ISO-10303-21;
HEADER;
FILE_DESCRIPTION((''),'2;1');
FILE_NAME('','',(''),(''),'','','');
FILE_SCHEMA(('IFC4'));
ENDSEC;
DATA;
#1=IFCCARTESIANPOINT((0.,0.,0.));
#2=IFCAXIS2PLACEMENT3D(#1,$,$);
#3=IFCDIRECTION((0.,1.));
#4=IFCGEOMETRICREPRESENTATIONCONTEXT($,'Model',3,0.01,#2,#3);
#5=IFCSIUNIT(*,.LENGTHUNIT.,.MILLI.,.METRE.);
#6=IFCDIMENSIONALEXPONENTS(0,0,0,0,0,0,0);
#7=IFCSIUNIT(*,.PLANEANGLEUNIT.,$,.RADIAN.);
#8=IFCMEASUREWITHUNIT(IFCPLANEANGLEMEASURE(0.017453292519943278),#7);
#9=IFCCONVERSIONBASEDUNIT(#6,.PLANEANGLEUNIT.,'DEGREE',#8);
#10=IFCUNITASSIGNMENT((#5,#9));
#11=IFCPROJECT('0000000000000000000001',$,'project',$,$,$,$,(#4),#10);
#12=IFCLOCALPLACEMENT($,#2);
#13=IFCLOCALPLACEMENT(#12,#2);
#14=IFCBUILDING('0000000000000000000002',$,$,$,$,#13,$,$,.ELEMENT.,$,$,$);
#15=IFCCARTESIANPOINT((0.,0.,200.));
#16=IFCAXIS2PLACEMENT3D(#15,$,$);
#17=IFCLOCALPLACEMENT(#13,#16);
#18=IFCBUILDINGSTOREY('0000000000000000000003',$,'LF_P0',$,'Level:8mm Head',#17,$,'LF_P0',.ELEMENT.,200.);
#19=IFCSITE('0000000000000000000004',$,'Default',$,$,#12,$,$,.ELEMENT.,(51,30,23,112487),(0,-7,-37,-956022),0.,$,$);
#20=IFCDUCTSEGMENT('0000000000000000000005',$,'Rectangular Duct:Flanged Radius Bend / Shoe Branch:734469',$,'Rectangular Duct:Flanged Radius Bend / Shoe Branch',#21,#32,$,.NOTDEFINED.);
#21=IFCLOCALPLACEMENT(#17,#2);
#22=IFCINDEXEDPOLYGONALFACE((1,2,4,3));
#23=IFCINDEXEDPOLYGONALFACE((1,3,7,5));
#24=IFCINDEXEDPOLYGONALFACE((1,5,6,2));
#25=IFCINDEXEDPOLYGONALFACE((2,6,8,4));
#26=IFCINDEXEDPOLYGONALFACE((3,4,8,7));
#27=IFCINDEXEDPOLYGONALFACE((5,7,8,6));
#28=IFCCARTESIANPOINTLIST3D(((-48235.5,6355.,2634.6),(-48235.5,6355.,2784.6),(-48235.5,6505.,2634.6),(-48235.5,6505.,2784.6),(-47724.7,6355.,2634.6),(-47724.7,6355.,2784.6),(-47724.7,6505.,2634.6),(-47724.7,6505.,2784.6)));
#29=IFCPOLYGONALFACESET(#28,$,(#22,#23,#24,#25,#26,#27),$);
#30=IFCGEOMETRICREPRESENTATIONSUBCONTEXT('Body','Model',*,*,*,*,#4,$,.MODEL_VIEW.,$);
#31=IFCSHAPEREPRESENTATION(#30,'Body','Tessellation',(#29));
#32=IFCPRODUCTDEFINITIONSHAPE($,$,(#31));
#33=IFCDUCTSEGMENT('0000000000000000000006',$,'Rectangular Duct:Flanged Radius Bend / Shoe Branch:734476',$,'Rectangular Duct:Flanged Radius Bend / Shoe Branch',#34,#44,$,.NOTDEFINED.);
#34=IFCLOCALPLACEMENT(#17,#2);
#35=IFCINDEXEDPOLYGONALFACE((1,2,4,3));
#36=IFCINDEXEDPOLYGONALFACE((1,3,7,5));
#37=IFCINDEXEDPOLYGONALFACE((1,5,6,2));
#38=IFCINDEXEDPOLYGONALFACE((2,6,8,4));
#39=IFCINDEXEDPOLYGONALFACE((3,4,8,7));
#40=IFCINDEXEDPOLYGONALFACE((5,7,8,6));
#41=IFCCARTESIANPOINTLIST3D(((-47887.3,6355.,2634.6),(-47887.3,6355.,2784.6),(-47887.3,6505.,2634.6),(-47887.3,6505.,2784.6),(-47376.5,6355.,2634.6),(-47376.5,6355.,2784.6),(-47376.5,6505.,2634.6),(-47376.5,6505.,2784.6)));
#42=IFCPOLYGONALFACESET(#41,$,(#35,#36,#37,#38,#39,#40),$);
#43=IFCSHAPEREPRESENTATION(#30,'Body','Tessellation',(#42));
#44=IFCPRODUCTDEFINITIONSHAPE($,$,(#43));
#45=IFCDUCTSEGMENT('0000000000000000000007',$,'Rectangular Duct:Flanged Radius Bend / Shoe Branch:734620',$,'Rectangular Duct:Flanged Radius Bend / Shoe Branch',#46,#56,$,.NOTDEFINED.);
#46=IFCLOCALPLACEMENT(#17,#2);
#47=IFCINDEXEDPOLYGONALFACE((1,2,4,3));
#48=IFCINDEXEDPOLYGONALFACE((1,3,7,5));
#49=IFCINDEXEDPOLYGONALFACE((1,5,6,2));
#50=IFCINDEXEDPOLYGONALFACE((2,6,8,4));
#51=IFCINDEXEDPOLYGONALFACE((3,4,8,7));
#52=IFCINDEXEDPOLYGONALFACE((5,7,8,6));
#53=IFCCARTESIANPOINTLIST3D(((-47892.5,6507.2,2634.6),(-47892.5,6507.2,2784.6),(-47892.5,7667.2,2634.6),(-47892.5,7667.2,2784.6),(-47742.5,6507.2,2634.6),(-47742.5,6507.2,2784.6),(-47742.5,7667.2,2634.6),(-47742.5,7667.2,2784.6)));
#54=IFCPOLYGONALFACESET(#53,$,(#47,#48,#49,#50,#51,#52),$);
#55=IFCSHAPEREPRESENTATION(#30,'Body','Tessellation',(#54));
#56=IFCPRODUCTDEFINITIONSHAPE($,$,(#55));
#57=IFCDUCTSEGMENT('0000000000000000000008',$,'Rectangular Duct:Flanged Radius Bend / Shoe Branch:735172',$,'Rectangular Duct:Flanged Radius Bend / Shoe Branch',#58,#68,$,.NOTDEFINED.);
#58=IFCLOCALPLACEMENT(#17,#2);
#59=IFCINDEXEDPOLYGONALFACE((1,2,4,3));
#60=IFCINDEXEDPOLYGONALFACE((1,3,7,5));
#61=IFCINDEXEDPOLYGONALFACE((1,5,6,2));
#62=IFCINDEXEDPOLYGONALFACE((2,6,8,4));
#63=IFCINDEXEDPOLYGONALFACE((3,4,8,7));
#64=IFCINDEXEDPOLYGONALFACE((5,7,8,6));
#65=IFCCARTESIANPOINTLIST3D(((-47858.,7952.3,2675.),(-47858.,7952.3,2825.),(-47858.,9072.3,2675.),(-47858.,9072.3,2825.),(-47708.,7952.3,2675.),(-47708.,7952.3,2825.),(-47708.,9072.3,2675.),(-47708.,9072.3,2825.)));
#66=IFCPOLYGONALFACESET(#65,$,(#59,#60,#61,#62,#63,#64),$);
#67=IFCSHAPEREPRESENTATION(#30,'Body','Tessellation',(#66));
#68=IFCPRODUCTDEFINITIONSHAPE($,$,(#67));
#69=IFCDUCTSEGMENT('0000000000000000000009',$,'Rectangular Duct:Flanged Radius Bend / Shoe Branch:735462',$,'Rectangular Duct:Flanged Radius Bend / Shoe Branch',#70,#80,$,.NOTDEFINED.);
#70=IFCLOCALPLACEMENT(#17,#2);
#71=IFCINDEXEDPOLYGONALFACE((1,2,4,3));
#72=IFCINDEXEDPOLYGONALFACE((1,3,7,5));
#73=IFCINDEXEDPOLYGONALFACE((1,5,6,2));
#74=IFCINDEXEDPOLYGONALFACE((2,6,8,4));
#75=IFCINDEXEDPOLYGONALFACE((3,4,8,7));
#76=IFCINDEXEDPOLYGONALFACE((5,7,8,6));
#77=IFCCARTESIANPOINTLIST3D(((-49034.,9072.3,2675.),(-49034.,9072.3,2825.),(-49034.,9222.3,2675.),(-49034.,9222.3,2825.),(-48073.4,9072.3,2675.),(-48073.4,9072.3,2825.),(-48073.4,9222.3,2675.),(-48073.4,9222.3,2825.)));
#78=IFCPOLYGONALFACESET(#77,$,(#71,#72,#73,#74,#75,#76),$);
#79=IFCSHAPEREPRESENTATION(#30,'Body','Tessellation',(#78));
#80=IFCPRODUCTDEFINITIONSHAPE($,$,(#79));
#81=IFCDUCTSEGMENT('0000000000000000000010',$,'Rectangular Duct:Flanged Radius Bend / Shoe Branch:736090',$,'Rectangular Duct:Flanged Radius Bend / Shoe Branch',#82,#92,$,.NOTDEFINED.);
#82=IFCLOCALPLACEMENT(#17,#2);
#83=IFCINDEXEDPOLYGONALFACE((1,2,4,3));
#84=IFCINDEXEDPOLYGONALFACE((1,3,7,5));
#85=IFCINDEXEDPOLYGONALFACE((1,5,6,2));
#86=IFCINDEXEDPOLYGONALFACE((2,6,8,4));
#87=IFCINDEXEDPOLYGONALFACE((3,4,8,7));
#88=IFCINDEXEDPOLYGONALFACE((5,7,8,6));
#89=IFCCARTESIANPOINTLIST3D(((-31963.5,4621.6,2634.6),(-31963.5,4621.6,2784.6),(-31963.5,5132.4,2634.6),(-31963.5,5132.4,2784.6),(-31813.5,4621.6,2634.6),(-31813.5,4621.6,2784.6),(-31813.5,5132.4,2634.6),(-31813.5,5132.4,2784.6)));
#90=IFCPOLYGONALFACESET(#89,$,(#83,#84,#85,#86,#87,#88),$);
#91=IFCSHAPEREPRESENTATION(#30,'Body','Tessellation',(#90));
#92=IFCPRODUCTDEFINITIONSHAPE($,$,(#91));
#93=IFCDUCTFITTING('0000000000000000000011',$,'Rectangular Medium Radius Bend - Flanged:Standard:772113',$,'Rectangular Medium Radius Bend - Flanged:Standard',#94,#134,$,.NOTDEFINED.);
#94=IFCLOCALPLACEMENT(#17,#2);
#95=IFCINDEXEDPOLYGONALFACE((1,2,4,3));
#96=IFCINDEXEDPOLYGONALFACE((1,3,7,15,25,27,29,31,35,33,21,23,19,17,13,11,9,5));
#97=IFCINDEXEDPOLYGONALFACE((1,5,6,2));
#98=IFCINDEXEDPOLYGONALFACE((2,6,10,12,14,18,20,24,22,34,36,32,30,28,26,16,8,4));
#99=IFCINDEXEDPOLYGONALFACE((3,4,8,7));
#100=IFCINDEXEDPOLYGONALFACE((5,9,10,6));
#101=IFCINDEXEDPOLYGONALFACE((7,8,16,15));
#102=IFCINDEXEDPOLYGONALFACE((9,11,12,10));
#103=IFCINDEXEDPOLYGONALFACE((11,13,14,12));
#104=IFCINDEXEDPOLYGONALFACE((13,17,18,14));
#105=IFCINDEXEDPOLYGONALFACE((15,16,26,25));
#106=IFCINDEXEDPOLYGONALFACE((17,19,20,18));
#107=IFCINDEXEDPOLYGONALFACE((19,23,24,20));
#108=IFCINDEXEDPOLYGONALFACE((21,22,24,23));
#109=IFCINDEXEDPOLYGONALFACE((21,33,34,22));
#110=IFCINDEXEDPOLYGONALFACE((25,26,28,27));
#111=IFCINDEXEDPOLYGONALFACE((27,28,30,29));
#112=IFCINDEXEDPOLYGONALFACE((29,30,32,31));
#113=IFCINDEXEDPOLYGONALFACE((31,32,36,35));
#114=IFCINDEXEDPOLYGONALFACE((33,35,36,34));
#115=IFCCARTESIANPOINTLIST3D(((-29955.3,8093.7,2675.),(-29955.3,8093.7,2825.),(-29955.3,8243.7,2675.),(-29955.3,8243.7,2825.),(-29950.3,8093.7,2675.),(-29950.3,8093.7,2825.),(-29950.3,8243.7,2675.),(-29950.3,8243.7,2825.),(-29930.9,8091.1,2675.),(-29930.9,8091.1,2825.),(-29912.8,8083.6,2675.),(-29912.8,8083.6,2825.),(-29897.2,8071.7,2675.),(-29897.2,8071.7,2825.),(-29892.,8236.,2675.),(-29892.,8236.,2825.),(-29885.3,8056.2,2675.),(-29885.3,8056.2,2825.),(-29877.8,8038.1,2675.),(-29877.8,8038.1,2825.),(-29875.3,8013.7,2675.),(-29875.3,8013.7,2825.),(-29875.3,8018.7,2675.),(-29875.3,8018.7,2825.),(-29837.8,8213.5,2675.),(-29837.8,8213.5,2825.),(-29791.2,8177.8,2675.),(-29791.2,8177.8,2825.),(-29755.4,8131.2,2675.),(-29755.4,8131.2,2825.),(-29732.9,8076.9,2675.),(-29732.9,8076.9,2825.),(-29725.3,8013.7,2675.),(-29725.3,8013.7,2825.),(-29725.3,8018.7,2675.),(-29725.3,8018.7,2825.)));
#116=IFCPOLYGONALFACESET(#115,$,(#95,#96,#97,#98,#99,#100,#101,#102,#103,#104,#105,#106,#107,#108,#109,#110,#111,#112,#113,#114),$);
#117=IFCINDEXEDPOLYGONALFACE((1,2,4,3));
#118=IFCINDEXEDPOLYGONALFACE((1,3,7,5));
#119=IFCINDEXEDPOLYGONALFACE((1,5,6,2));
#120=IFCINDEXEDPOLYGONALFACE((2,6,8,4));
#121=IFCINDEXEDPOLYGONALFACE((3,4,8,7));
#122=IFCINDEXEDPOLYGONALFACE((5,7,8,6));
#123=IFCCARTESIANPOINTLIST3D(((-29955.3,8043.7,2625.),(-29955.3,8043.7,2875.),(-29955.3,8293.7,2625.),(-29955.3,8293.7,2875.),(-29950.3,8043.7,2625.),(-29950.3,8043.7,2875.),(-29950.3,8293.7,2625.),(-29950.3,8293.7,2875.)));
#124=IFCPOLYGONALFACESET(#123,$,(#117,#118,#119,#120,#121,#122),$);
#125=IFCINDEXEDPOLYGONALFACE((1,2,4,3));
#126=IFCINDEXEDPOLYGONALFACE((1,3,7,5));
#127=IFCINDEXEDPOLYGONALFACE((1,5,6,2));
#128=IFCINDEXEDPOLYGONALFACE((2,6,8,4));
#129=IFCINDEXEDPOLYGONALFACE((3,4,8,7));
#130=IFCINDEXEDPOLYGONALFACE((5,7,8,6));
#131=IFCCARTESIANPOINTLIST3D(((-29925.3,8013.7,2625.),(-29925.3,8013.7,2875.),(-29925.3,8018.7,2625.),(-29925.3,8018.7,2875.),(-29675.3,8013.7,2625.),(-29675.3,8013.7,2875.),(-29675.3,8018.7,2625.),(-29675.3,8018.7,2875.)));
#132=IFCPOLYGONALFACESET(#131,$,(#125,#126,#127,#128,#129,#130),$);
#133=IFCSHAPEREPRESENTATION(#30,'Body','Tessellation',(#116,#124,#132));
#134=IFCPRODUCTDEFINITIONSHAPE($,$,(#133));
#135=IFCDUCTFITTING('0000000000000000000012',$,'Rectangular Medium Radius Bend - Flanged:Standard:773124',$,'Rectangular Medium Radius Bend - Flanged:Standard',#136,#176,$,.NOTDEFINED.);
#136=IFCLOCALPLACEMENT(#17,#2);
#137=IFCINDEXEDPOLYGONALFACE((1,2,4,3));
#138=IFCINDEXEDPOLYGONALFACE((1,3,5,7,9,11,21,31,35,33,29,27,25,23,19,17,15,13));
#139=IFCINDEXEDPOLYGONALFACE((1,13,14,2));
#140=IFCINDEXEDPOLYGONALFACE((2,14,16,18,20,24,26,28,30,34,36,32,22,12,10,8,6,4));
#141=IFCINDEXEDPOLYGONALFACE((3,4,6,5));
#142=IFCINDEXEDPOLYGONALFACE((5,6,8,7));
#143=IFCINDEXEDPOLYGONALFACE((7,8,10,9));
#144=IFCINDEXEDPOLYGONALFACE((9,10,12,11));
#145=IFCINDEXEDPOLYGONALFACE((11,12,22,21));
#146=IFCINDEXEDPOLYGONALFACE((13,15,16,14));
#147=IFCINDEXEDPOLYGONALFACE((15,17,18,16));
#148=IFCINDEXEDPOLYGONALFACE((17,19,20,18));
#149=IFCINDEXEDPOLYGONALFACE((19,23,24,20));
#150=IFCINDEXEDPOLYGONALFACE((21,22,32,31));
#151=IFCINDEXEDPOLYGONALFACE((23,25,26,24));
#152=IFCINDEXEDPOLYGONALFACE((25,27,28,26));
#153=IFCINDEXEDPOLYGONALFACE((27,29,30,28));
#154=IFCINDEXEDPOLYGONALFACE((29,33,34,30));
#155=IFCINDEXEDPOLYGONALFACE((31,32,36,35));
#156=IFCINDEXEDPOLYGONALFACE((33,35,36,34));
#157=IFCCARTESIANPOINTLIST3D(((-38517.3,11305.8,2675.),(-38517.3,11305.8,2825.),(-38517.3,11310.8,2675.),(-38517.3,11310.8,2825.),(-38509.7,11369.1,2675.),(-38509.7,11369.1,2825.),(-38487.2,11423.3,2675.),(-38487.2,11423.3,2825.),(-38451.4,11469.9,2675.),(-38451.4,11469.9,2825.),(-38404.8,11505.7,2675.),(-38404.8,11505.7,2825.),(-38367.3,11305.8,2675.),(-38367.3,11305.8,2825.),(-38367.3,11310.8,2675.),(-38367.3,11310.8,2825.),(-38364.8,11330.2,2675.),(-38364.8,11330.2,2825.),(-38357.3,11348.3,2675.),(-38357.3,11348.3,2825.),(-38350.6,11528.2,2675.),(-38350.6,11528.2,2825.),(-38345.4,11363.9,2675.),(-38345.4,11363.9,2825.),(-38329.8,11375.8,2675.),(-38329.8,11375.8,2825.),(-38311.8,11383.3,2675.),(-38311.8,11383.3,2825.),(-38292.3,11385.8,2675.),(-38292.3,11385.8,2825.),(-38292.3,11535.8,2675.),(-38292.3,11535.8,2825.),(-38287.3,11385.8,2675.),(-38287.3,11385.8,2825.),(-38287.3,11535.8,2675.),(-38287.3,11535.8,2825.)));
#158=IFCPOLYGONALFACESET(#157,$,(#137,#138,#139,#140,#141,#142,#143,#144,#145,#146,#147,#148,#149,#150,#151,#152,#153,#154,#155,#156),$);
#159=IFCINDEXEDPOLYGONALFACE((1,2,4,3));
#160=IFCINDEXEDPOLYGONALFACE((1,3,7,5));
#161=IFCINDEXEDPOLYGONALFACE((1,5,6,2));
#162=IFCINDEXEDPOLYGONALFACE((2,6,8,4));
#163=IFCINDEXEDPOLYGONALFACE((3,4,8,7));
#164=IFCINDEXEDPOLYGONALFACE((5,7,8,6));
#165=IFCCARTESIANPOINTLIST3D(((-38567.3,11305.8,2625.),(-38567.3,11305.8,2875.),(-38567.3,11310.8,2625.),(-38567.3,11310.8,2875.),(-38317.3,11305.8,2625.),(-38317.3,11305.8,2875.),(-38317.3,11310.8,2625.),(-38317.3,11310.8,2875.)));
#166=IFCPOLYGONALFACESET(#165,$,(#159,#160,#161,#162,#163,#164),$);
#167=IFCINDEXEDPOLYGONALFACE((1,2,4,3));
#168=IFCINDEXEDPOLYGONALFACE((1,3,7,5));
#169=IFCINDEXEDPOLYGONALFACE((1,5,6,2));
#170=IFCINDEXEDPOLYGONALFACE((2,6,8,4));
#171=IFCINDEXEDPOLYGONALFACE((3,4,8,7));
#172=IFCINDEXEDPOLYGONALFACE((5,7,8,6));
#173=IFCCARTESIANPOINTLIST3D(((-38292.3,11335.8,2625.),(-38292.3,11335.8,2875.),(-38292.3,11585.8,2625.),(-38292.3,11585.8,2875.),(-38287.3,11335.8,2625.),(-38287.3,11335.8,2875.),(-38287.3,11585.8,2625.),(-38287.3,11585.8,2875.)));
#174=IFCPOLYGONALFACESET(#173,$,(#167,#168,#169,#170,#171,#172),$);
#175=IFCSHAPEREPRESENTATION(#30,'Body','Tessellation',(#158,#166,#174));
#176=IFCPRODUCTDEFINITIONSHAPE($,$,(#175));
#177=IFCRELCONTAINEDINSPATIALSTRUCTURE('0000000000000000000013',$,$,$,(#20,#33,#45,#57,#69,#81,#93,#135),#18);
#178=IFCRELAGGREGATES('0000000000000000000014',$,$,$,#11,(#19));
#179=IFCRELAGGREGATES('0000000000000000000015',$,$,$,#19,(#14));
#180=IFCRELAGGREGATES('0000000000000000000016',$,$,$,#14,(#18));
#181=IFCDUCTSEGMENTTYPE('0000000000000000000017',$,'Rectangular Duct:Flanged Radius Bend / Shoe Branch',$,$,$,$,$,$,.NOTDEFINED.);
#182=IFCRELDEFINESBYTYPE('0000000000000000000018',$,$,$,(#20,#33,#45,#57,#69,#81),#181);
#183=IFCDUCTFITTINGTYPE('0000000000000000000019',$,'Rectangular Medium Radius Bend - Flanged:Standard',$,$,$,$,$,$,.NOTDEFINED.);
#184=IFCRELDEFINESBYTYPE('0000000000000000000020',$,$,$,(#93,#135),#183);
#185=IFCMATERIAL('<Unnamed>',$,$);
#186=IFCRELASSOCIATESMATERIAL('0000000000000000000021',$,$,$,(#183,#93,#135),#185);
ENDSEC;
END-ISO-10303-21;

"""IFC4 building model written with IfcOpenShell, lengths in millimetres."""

from ifc_helpers import new_model, entity, si_unit, converted_unit, direction, frame, origin, place, context, subcontext, project, spatial, line, arc, indexed_curve, outline, extrude, source, transform, mapped, material, type_object, type_shapes, element, save


model = new_model("IFC4")

# Units and contexts
model_context = context("Model", 3, precision=0.01, world=origin(), true_north=direction((0.0, 1.0)))
body_context = subcontext(model_context, "Body", "Model", "MODEL_VIEW")
ifc_project = project(units=[si_unit("LENGTHUNIT", "METRE", prefix="MILLI"), converted_unit("PLANEANGLEUNIT", "DEGREE", entity("IfcPlaneAngleMeasure", 0.017453292519943278), si_unit("PLANEANGLEUNIT", "RADIAN"), dimensions=[0, 0, 0, 0, 0, 0, 0])], contexts=[model_context])

# Site, building, storey
site_placement = place(None, origin())
site = spatial("IfcSite", under=ifc_project, at=site_placement, Name="Default", CompositionType="ELEMENT", RefLatitude=(51, 30, 23, 112487), RefLongitude=(0, -7, -37, -956022), RefElevation=0.0)
building_placement = place(site_placement, origin())
building = spatial("IfcBuilding", under=site, at=building_placement, CompositionType="ELEMENT")
storey_placement = place(building_placement, frame((0.0, 0.0, 200.0)))
storey = spatial("IfcBuildingStorey", under=building, at=storey_placement, Name="LF_P0", ObjectType="Level:8mm Head", LongName="LF_P0", CompositionType="ELEMENT", Elevation=200.0)

# Duct segments
duct_segment_type_1 = type_object("IfcDuctSegmentType", Name="Rectangular Duct:Flanged Radius Bend / Shoe Branch", PredefinedType="NOTDEFINED")
duct_segment_1_placement = place(storey_placement, origin())
element("IfcDuctSegment", 1, at=duct_segment_1_placement, inside=storey, type_object=duct_segment_type_1, Name="Rectangular Duct:Flanged Radius Bend / Shoe Branch:734469", ObjectType="Rectangular Duct:Flanged Radius Bend / Shoe Branch", PredefinedType="NOTDEFINED", context=body_context, shape_type="SweptSolid", body=[
    extrude(outline(indexed_curve([(-255.4, -75.0), (255.4, -75.0), (255.4, 75.0), (-255.4, 75.0), (-255.4, -75.0)], self_intersect=False)), frame((-47980.1, 6430.0, 2634.6)), (0.0, 0.0, 1.0), 150.0),
])
duct_segment_2_placement = place(storey_placement, origin())
element("IfcDuctSegment", 2, at=duct_segment_2_placement, inside=storey, type_object=duct_segment_type_1, Name="Rectangular Duct:Flanged Radius Bend / Shoe Branch:734476", ObjectType="Rectangular Duct:Flanged Radius Bend / Shoe Branch", PredefinedType="NOTDEFINED", context=body_context, shape_type="SweptSolid", body=[
    extrude(outline(indexed_curve([(-255.4, -75.0), (255.4, -75.0), (255.4, 75.0), (-255.4, 75.0), (-255.4, -75.0)], self_intersect=False)), frame((-47631.9, 6430.0, 2634.6), z_axis=(0.0, 0.0, 1.0), x_axis=(-1.0, 0.0, 0.0)), (0.0, 0.0, 1.0), 150.0),
])
duct_segment_3_placement = place(storey_placement, origin())
element("IfcDuctSegment", 3, at=duct_segment_3_placement, inside=storey, type_object=duct_segment_type_1, Name="Rectangular Duct:Flanged Radius Bend / Shoe Branch:734620", ObjectType="Rectangular Duct:Flanged Radius Bend / Shoe Branch", PredefinedType="NOTDEFINED", context=body_context, shape_type="SweptSolid", body=[
    extrude(outline(indexed_curve([(-580.0, -75.0), (580.0, -75.0), (580.0, 75.0), (-580.0, 75.0), (-580.0, -75.0)], self_intersect=False)), frame((-47817.5, 7087.2, 2634.6), z_axis=(0.0, 0.0, 1.0), x_axis=(0.0, -1.0, 0.0)), (0.0, 0.0, 1.0), 150.0),
])
duct_segment_4_placement = place(storey_placement, origin())
element("IfcDuctSegment", 4, at=duct_segment_4_placement, inside=storey, type_object=duct_segment_type_1, Name="Rectangular Duct:Flanged Radius Bend / Shoe Branch:735172", ObjectType="Rectangular Duct:Flanged Radius Bend / Shoe Branch", PredefinedType="NOTDEFINED", context=body_context, shape_type="SweptSolid", body=[
    extrude(outline(indexed_curve([(-560.0, -75.0), (560.0, -75.0), (560.0, 75.0), (-560.0, 75.0), (-560.0, -75.0)], self_intersect=False)), frame((-47783.0, 8512.3, 2675.0), z_axis=(0.0, 0.0, 1.0), x_axis=(0.0, 1.0, 0.0)), (0.0, 0.0, 1.0), 150.0),
])
duct_segment_5_placement = place(storey_placement, origin())
element("IfcDuctSegment", 5, at=duct_segment_5_placement, inside=storey, type_object=duct_segment_type_1, Name="Rectangular Duct:Flanged Radius Bend / Shoe Branch:735462", ObjectType="Rectangular Duct:Flanged Radius Bend / Shoe Branch", PredefinedType="NOTDEFINED", context=body_context, shape_type="SweptSolid", body=[
    extrude(outline(indexed_curve([(-480.3, -75.0), (480.3, -75.0), (480.3, 75.0), (-480.3, 75.0), (-480.3, -75.0)], self_intersect=False)), frame((-48553.7, 9147.3, 2675.0), z_axis=(0.0, 0.0, 1.0), x_axis=(-1.0, 0.0, 0.0)), (0.0, 0.0, 1.0), 150.0),
])
duct_segment_6_placement = place(storey_placement, origin())
element("IfcDuctSegment", 6, at=duct_segment_6_placement, inside=storey, type_object=duct_segment_type_1, Name="Rectangular Duct:Flanged Radius Bend / Shoe Branch:736090", ObjectType="Rectangular Duct:Flanged Radius Bend / Shoe Branch", PredefinedType="NOTDEFINED", context=body_context, shape_type="SweptSolid", body=[
    extrude(outline(indexed_curve([(-255.4, -75.0), (255.4, -75.0), (255.4, 75.0), (-255.4, 75.0), (-255.4, -75.0)], self_intersect=False)), frame((-31888.5, 4877.0, 2634.6), z_axis=(0.0, 0.0, 1.0), x_axis=(0.0, -1.0, 0.0)), (0.0, 0.0, 1.0), 150.0),
])

# Duct fittings
ifc_material = material(Name="<Unnamed>")
duct_fitting_type = type_object("IfcDuctFittingType", Name="Rectangular Medium Radius Bend - Flanged:Standard", PredefinedType="NOTDEFINED", material=ifc_material)
shared_shape_1 = source(origin(), body_context, "Body", "SweptSolid", [
    extrude(outline(indexed_curve([(-78.8, -151.2), (-73.7, -151.2), (85.3, -85.3), (151.3, 73.7), (151.3, 78.7), (1.3, 78.7), (1.3, 73.8), (-20.7, 20.7), (-73.7, -1.2), (-78.8, -1.2)], segments=[line(1, 2), arc(2, 3, 4), line(4, 5, 6, 7), arc(7, 8, 9), line(9, 10, 1)], self_intersect=False)), frame((-76.2, 76.2, -75.0)), (0.0, 0.0, 1.0), 150.0),
    extrude(outline(indexed_curve([(-2.5, -125.0), (2.5, -125.0), (2.5, 125.0), (-2.5, 125.0), (-2.5, -125.0)], self_intersect=False)), frame((0.0, 152.5, -125.0), z_axis=(0.0, 0.0, 1.0), x_axis=(0.0, 1.0, 0.0)), (0.0, 0.0, 1.0), 250.0),
    extrude(outline(indexed_curve([(-2.5, -125.0), (2.5, -125.0), (2.5, 125.0), (-2.5, 125.0), (-2.5, -125.0)], self_intersect=False)), frame((-152.5, 0.0, -125.0)), (0.0, 0.0, 1.0), 250.0),
])
type_shapes(duct_fitting_type, [shared_shape_1])
for number, where, z_axis, x_axis, name in (
    (7, (-29800.3, 8168.7, 2750.0), (0.0, 0.0, 1.0), (0.0, 1.0, 0.0), "Rectangular Medium Radius Bend - Flanged:Standard:772113"),
    (8, (-38442.3, 11460.8, 2750.0), (0.0, 0.0, 1.0), (-1.0, 0.0, 0.0), "Rectangular Medium Radius Bend - Flanged:Standard:773124"),
):
    element("IfcDuctFitting", number, at=place(storey_placement, frame(where, z_axis=z_axis, x_axis=x_axis)), inside=storey, type_object=duct_fitting_type, material=ifc_material, Name=name, ObjectType="Rectangular Medium Radius Bend - Flanged:Standard", PredefinedType="NOTDEFINED", context=body_context, shape_type="MappedRepresentation", body=[
        mapped(shared_shape_1, transform((0.0, 0.0, 0.0), scale=1.0)),
    ])

save(model, "model.ifc")
